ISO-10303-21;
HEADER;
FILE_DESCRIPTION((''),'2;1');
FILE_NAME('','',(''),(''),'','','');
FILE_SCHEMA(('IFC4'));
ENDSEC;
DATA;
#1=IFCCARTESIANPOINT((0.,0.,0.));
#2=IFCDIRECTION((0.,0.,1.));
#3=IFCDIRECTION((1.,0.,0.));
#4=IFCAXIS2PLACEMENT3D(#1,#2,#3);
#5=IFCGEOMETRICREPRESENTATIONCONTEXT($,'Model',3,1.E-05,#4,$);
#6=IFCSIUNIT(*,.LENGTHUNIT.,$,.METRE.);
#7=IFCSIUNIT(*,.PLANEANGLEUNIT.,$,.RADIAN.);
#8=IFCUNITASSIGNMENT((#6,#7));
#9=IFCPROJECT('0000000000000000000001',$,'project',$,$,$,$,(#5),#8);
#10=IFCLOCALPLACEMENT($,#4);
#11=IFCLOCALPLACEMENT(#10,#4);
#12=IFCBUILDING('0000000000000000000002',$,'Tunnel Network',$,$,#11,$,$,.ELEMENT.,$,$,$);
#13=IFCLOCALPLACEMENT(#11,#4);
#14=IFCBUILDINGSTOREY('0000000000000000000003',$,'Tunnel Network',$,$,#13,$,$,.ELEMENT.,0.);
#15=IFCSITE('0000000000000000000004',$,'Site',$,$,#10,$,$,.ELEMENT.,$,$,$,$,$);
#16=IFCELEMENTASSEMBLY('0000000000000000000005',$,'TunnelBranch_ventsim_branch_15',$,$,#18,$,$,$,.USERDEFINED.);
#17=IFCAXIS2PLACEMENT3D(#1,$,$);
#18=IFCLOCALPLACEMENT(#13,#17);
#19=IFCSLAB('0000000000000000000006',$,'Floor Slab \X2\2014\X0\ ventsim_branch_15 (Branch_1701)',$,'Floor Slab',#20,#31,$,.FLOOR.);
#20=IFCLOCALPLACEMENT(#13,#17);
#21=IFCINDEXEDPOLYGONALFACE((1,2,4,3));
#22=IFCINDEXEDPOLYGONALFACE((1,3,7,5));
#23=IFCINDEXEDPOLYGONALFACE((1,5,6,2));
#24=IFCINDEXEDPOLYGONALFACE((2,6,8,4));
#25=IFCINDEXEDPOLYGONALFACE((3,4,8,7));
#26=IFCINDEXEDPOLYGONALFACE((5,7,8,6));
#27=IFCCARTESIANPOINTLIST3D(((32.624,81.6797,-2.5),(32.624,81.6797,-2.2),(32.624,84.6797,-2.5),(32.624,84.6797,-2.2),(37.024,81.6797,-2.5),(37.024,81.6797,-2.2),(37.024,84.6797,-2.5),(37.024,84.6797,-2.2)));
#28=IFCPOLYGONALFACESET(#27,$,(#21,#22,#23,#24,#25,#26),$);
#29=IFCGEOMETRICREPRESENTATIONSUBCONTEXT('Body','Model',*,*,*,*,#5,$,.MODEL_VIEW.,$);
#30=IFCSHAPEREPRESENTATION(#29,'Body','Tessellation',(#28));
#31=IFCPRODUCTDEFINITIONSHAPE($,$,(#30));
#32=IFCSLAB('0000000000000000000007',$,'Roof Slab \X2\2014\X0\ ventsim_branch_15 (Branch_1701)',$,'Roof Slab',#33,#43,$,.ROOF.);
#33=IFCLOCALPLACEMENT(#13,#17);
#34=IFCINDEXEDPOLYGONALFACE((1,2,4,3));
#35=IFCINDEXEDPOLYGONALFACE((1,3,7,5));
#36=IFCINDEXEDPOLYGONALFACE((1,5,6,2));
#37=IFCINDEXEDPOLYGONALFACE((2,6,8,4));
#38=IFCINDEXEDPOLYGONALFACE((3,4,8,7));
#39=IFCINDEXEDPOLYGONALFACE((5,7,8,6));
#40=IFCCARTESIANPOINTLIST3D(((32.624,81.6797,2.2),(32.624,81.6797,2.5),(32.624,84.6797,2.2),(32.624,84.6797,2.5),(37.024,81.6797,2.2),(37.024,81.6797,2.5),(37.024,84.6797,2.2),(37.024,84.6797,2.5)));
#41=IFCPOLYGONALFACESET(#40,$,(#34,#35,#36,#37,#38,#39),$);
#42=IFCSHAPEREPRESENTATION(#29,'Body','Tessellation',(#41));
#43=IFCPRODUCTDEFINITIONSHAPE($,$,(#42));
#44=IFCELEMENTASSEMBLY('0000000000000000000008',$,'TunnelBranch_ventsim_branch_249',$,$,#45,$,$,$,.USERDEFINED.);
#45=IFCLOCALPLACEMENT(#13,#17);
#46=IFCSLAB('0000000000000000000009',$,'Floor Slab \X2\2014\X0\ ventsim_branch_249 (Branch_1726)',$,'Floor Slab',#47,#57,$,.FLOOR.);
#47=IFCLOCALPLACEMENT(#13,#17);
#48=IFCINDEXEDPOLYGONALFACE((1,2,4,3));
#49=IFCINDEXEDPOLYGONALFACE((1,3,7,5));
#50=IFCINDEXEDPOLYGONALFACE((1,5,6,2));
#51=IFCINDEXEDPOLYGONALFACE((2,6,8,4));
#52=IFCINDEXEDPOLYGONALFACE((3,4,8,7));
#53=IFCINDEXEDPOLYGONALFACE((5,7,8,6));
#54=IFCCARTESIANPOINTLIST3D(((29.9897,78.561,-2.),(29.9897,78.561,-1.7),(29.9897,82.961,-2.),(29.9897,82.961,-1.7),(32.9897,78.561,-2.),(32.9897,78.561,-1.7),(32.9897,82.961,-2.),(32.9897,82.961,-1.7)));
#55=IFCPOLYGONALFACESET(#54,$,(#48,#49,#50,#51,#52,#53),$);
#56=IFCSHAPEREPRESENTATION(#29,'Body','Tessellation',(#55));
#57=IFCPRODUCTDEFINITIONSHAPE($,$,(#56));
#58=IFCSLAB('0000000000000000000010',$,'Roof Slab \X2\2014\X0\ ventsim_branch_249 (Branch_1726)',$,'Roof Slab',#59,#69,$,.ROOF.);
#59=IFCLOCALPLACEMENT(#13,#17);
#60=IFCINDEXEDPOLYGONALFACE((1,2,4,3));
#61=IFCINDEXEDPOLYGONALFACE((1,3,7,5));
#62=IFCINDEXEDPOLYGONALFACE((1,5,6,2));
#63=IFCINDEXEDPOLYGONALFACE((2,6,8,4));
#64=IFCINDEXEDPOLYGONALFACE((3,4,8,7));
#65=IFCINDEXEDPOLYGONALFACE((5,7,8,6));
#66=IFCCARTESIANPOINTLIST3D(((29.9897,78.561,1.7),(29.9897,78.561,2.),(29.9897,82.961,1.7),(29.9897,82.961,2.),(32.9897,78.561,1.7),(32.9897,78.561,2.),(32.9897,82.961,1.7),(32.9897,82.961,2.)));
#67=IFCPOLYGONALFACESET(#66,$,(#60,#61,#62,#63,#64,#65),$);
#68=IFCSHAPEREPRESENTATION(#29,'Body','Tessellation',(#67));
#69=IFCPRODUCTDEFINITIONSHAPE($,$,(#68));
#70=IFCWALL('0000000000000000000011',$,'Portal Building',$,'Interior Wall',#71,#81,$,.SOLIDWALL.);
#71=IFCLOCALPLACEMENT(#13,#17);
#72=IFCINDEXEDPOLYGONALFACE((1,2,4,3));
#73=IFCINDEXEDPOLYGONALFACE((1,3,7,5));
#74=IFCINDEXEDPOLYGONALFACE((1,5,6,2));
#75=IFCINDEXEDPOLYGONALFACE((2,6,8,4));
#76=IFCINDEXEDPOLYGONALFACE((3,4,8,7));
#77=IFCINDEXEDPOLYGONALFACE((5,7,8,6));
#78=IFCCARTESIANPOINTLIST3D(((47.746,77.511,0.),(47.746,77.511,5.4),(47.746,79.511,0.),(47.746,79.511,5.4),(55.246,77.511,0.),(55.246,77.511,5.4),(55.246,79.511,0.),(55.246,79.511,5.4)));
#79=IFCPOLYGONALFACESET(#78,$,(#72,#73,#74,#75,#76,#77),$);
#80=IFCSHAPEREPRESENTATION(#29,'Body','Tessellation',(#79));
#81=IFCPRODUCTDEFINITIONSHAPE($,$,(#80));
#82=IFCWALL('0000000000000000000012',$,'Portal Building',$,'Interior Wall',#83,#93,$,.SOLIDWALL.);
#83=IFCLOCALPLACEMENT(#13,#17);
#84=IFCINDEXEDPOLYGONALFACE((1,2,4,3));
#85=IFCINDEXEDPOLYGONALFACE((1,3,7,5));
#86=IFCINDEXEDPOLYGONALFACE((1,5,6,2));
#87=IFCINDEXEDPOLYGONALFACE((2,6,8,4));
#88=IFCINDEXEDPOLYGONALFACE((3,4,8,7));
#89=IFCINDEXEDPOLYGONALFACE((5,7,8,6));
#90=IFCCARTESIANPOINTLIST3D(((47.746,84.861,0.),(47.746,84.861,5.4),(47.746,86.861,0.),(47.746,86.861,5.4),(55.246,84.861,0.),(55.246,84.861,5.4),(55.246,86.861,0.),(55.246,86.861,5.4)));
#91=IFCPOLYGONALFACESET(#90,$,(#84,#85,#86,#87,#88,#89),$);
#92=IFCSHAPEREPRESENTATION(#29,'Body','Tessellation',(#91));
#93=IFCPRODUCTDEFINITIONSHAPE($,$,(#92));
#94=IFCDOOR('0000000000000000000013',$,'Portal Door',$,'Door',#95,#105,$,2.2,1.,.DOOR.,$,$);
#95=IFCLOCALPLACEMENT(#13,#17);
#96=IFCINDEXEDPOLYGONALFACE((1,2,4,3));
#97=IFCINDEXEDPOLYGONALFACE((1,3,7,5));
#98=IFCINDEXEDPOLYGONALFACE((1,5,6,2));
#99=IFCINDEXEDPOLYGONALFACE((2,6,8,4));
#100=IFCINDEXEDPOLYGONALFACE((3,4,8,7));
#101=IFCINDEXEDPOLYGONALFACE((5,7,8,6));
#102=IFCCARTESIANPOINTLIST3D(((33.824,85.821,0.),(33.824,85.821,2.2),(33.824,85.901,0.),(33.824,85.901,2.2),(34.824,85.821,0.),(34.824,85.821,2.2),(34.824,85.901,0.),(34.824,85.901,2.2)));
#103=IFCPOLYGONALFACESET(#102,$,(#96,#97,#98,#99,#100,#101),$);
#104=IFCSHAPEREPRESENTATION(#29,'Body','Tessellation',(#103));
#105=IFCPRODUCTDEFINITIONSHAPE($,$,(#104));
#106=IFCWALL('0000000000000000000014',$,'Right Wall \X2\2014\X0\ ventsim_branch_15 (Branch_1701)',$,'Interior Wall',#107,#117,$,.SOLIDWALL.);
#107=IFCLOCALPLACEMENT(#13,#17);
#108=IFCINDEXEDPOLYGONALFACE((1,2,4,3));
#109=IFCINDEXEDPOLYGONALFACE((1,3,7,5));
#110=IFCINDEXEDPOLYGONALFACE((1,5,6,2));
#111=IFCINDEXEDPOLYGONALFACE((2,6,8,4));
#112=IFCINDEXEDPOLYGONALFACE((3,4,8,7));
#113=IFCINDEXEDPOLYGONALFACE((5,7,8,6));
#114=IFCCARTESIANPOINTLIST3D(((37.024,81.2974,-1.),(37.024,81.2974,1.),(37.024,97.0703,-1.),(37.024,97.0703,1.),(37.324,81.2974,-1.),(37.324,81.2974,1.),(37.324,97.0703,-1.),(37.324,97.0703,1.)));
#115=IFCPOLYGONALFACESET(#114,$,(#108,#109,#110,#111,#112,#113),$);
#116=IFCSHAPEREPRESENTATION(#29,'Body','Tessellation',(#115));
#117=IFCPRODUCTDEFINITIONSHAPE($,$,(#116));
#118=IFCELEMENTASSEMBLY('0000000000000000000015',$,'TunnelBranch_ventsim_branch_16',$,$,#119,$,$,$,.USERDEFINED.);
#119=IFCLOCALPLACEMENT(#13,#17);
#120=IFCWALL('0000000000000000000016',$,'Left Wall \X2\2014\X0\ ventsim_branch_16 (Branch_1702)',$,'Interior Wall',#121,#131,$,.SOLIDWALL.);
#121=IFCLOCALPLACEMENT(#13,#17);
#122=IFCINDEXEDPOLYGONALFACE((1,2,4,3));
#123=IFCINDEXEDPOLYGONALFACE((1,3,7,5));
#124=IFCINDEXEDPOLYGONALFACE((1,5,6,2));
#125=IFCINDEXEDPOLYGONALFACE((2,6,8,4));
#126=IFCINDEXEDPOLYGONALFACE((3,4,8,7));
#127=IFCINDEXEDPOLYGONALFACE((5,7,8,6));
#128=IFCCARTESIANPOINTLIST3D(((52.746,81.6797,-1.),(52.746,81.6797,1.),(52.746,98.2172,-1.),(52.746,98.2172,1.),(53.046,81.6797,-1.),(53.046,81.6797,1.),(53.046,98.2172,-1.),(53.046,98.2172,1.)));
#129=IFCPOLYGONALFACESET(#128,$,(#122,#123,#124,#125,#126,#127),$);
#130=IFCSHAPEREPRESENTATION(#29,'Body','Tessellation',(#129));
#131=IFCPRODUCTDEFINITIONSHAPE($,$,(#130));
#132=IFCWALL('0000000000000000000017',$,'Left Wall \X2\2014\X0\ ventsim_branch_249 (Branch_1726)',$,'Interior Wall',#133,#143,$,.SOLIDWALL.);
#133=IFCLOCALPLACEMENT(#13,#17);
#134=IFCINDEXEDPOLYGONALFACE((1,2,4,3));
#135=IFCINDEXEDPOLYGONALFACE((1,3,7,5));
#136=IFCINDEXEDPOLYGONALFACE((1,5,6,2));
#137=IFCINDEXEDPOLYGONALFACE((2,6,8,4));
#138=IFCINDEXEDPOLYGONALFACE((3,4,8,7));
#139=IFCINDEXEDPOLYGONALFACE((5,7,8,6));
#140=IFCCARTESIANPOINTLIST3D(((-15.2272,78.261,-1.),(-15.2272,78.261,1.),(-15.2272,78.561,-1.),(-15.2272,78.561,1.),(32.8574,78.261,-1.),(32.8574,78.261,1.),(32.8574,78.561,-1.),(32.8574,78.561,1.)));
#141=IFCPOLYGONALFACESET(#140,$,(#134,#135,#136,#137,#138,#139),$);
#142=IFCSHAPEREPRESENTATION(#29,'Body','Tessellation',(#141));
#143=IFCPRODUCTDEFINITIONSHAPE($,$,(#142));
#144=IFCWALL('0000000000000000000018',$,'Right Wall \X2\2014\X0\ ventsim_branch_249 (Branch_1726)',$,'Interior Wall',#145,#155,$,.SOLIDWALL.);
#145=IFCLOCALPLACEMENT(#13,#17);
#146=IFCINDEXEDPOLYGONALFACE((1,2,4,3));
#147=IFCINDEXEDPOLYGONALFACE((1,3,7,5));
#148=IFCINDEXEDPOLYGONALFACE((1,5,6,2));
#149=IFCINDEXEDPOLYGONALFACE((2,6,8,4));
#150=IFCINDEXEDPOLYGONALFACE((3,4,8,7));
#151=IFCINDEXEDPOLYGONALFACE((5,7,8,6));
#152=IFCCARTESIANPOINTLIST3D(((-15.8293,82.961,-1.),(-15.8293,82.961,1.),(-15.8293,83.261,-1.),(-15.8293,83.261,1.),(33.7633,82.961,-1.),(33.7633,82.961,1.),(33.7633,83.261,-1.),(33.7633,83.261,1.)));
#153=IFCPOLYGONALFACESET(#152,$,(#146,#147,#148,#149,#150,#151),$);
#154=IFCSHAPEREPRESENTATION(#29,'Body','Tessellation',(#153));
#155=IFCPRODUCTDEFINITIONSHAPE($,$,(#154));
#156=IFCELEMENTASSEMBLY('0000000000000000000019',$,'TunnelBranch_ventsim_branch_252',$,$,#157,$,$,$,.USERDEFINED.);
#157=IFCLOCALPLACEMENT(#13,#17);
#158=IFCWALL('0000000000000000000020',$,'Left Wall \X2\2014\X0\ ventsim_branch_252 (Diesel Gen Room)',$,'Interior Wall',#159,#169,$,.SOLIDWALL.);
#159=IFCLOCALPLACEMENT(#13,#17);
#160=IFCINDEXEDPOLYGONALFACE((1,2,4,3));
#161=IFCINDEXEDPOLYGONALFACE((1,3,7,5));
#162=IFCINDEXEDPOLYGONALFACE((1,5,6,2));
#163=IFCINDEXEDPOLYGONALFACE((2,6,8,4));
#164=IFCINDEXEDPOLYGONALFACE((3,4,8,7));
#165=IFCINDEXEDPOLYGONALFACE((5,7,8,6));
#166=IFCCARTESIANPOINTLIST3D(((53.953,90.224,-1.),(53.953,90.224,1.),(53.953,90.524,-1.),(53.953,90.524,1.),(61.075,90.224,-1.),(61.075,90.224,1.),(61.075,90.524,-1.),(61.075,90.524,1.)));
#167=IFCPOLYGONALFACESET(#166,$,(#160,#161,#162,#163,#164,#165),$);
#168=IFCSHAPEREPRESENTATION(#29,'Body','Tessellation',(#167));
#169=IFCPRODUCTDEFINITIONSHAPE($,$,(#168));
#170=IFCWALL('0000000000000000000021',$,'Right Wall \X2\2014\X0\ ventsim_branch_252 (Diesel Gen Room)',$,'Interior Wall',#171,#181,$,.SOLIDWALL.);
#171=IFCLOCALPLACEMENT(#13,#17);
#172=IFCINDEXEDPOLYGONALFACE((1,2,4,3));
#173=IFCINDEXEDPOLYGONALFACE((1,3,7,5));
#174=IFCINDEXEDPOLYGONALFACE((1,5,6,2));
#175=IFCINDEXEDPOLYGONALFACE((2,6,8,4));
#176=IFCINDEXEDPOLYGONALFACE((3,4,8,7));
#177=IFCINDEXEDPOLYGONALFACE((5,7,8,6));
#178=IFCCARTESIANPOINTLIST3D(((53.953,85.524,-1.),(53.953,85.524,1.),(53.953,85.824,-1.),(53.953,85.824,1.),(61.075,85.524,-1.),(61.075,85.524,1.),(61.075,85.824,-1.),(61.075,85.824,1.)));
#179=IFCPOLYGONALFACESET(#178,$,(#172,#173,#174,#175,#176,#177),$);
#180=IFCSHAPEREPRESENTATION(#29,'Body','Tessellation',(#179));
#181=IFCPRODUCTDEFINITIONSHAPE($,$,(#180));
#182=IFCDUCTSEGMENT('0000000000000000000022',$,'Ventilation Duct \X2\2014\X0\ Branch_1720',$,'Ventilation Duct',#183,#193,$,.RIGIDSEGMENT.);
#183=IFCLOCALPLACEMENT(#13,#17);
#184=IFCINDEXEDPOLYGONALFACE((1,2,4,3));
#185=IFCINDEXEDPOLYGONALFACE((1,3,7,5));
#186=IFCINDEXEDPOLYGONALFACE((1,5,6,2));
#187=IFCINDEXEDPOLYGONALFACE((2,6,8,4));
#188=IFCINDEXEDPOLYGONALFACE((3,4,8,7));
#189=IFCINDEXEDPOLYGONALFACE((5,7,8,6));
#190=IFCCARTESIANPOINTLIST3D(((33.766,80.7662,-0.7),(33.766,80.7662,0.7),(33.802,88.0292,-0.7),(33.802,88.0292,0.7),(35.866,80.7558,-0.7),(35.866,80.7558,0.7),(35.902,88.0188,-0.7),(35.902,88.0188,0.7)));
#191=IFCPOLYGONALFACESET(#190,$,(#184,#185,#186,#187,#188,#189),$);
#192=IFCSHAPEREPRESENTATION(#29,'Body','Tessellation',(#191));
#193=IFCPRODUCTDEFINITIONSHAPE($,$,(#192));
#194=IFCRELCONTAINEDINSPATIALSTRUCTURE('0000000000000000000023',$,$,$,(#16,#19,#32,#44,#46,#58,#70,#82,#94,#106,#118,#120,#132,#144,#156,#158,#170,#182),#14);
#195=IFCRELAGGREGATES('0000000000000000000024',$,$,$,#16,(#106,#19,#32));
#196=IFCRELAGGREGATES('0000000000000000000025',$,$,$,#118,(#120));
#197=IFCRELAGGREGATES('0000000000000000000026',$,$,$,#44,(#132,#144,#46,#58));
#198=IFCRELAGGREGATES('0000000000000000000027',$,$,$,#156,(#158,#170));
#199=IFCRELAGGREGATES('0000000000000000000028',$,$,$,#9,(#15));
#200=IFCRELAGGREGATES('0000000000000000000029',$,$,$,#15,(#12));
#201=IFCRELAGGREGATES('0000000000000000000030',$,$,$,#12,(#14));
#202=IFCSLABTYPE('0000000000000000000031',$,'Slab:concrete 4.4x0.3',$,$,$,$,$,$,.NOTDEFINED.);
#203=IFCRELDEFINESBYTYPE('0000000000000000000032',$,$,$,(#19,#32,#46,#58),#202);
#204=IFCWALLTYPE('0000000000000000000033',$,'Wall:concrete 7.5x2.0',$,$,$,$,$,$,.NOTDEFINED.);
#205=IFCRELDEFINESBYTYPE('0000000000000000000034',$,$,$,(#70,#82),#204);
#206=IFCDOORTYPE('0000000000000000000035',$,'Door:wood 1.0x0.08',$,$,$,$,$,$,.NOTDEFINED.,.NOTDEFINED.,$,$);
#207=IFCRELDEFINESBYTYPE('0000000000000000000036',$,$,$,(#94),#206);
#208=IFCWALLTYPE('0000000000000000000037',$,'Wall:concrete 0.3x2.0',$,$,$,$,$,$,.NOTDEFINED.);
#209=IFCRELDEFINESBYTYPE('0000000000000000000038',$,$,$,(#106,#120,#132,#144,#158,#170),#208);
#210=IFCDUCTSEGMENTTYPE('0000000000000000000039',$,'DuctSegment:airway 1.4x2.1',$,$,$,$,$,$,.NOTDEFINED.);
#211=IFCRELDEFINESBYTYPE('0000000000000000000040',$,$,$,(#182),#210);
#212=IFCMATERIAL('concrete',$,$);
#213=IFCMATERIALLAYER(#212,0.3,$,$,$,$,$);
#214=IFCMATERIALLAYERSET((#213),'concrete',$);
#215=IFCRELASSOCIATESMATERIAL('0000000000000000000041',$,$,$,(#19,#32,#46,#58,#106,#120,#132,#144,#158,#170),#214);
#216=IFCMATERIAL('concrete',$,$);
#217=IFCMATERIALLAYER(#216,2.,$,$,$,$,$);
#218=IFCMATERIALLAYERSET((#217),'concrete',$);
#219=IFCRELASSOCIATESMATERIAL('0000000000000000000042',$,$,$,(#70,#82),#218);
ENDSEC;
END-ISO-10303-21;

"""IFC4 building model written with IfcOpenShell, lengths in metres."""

from ifc_helpers import new_model, si_unit, frame, origin_with_axes, origin_2d_with_axis, place, context, subcontext, project, spatial, rectangle, extrude, material, layer, layer_set, layer_usage, type_object, element, aggregate, save


model = new_model("IFC4")

# Units and contexts
model_context = context("Model", 3, precision=1e-05, world=origin_with_axes())
body_context = subcontext(model_context, "Body", "Model", "MODEL_VIEW")
ifc_project = project(units=[si_unit("LENGTHUNIT", "METRE"), si_unit("PLANEANGLEUNIT", "RADIAN")], contexts=[model_context])

# Site, building, storey
site_placement = place(None, origin_with_axes())
site = spatial("IfcSite", under=ifc_project, at=site_placement, Name="Site", CompositionType="ELEMENT")
building_placement = place(site_placement, origin_with_axes())
building = spatial("IfcBuilding", under=site, at=building_placement, Name="Tunnel Network", CompositionType="ELEMENT")
storey_placement = place(building_placement, origin_with_axes())
storey = spatial("IfcBuildingStorey", under=building, at=storey_placement, Name="Tunnel Network", CompositionType="ELEMENT", Elevation=0.0)

# Element assemblies, slabs
assembly_1_placement = place(storey_placement, frame((32.474, 81.6797, 0.0), z_axis=(0.0, 1.0, 0.0), x_axis=(1.0, 0.0, 0.0)))
assembly_1 = element("IfcElementAssembly", 1, at=assembly_1_placement, inside=storey, Name="TunnelBranch_ventsim_branch_15", PredefinedType="USERDEFINED")
ifc_material_1 = material(Name="concrete")
ifc_layer_1 = layer(ifc_material_1, 0.3)
ifc_layer_set_1 = layer_set([ifc_layer_1], Name="concrete")
ifc_layer_usage_1 = layer_usage(ifc_layer_set_1, "AXIS3", "POSITIVE", 0.0)
slab_type = type_object("IfcSlabType", Name="Slab:concrete 4.4x0.3")
slab_1_placement = place(storey_placement, frame((34.824, 81.6797, -2.35), z_axis=(0.0, 1.0, 0.0), x_axis=(1.0, 0.0, 0.0)))
slab_1 = element("IfcSlab", 2, at=slab_1_placement, inside=storey, type_object=slab_type, material=ifc_layer_usage_1, Name="Floor Slab — ventsim_branch_15 (Branch_1701)", ObjectType="Floor Slab", PredefinedType="FLOOR", context=body_context, shape_type="SweptSolid", body=[
    extrude(rectangle(XDim=4.4, YDim=0.3, at=origin_2d_with_axis()), origin_with_axes(), (0.0, 0.0, 1.0), 3.0),
])
ifc_layer_usage_2 = layer_usage(ifc_layer_set_1, "AXIS3", "POSITIVE", 0.0)
slab_2_placement = place(storey_placement, frame((34.824, 81.6797, 2.35), z_axis=(0.0, 1.0, 0.0), x_axis=(1.0, 0.0, 0.0)))
slab_2 = element("IfcSlab", 3, at=slab_2_placement, inside=storey, type_object=slab_type, material=ifc_layer_usage_2, Name="Roof Slab — ventsim_branch_15 (Branch_1701)", ObjectType="Roof Slab", PredefinedType="ROOF", context=body_context, shape_type="SweptSolid", body=[
    extrude(rectangle(XDim=4.4, YDim=0.3, at=origin_2d_with_axis()), origin_with_axes(), (0.0, 0.0, 1.0), 3.0),
])
assembly_2_placement = place(storey_placement, frame((32.8574, 78.411, 0.0), z_axis=(-1.0, 0.0, 0.0), x_axis=(0.0, 1.0, 0.0)))
assembly_2 = element("IfcElementAssembly", 4, at=assembly_2_placement, inside=storey, Name="TunnelBranch_ventsim_branch_249", PredefinedType="USERDEFINED")
ifc_layer_usage_3 = layer_usage(ifc_layer_set_1, "AXIS3", "POSITIVE", 0.0)
slab_3_placement = place(storey_placement, frame((32.9897, 80.761, -1.85), z_axis=(-1.0, 0.0, 0.0), x_axis=(0.0, 1.0, 0.0)))
slab_3 = element("IfcSlab", 5, at=slab_3_placement, inside=storey, type_object=slab_type, material=ifc_layer_usage_3, Name="Floor Slab — ventsim_branch_249 (Branch_1726)", ObjectType="Floor Slab", PredefinedType="FLOOR", context=body_context, shape_type="SweptSolid", body=[
    extrude(rectangle(XDim=4.4, YDim=0.3, at=origin_2d_with_axis()), origin_with_axes(), (0.0, 0.0, 1.0), 3.0),
])
ifc_layer_usage_4 = layer_usage(ifc_layer_set_1, "AXIS3", "POSITIVE", 0.0)
slab_4_placement = place(storey_placement, frame((32.9897, 80.761, 1.85), z_axis=(-1.0, 0.0, 0.0), x_axis=(0.0, 1.0, 0.0)))
slab_4 = element("IfcSlab", 6, at=slab_4_placement, inside=storey, type_object=slab_type, material=ifc_layer_usage_4, Name="Roof Slab — ventsim_branch_249 (Branch_1726)", ObjectType="Roof Slab", PredefinedType="ROOF", context=body_context, shape_type="SweptSolid", body=[
    extrude(rectangle(XDim=4.4, YDim=0.3, at=origin_2d_with_axis()), origin_with_axes(), (0.0, 0.0, 1.0), 3.0),
])

# Walls
ifc_material_2 = material(Name="concrete")
ifc_layer_2 = layer(ifc_material_2, 2.0)
ifc_layer_set_2 = layer_set([ifc_layer_2], Name="concrete")
ifc_layer_usage_5 = layer_usage(ifc_layer_set_2, "AXIS2", "POSITIVE", 0.0)
wall_type_1 = type_object("IfcWallType", Name="Wall:concrete 7.5x2.0")
wall_1_placement = place(storey_placement, frame((51.496, 78.511, 0.0), z_axis=(0.0, 0.0, 1.0), x_axis=(1.0, 0.0, 0.0)))
element("IfcWall", 7, at=wall_1_placement, inside=storey, type_object=wall_type_1, material=ifc_layer_usage_5, Name="Portal Building", ObjectType="Interior Wall", PredefinedType="SOLIDWALL", context=body_context, shape_type="SweptSolid", body=[
    extrude(rectangle(XDim=7.5, YDim=2.0, at=origin_2d_with_axis()), origin_with_axes(), (0.0, 0.0, 1.0), 5.4),
])
ifc_layer_usage_6 = layer_usage(ifc_layer_set_2, "AXIS2", "POSITIVE", 0.0)
wall_2_placement = place(storey_placement, frame((51.496, 85.861, 0.0), z_axis=(0.0, 0.0, 1.0), x_axis=(1.0, 0.0, 0.0)))
element("IfcWall", 8, at=wall_2_placement, inside=storey, type_object=wall_type_1, material=ifc_layer_usage_6, Name="Portal Building", ObjectType="Interior Wall", PredefinedType="SOLIDWALL", context=body_context, shape_type="SweptSolid", body=[
    extrude(rectangle(XDim=7.5, YDim=2.0, at=origin_2d_with_axis()), origin_with_axes(), (0.0, 0.0, 1.0), 5.4),
])

# Door
door_type = type_object("IfcDoorType", Name="Door:wood 1.0x0.08")
door_placement = place(storey_placement, frame((34.324, 85.861, 0.0), z_axis=(0.0, 0.0, 1.0), x_axis=(1.0, 0.0, 0.0)))
element("IfcDoor", 9, at=door_placement, inside=storey, type_object=door_type, Name="Portal Door", ObjectType="Door", OverallHeight=2.2, OverallWidth=1.0, PredefinedType="DOOR", context=body_context, shape_type="SweptSolid", body=[
    extrude(rectangle(XDim=1.0, YDim=0.08, at=origin_2d_with_axis()), origin_with_axes(), (0.0, 0.0, 1.0), 2.2),
])

# Wall
ifc_layer_usage_7 = layer_usage(ifc_layer_set_1, "AXIS2", "POSITIVE", 0.0)
wall_type_2 = type_object("IfcWallType", Name="Wall:concrete 0.3x2.0")
wall_3_placement = place(storey_placement, frame((37.174, 81.2974, 0.0), z_axis=(0.0, 1.0, 0.0), x_axis=(1.0, 0.0, 0.0)))
wall_3 = element("IfcWall", 10, at=wall_3_placement, inside=storey, type_object=wall_type_2, material=ifc_layer_usage_7, Name="Right Wall — ventsim_branch_15 (Branch_1701)", ObjectType="Interior Wall", PredefinedType="SOLIDWALL", context=body_context, shape_type="SweptSolid", body=[
    extrude(rectangle(XDim=0.3, YDim=2.0, at=origin_2d_with_axis()), origin_with_axes(), (0.0, 0.0, 1.0), 15.7728),
])
aggregate(assembly_1, [wall_3, slab_1, slab_2])

# Element assembly, wall
assembly_3_placement = place(storey_placement, frame((52.896, 81.6797, 0.0), z_axis=(0.0, 1.0, 0.0), x_axis=(1.0, 0.0, 0.0)))
assembly_3 = element("IfcElementAssembly", 11, at=assembly_3_placement, inside=storey, Name="TunnelBranch_ventsim_branch_16", PredefinedType="USERDEFINED")
ifc_layer_usage_8 = layer_usage(ifc_layer_set_1, "AXIS2", "POSITIVE", 0.0)
wall_4_placement = place(storey_placement, frame((52.896, 81.6797, 0.0), z_axis=(0.0, 1.0, 0.0), x_axis=(1.0, 0.0, 0.0)))
wall_4 = element("IfcWall", 12, at=wall_4_placement, inside=storey, type_object=wall_type_2, material=ifc_layer_usage_8, Name="Left Wall — ventsim_branch_16 (Branch_1702)", ObjectType="Interior Wall", PredefinedType="SOLIDWALL", context=body_context, shape_type="SweptSolid", body=[
    extrude(rectangle(XDim=0.3, YDim=2.0, at=origin_2d_with_axis()), origin_with_axes(), (0.0, 0.0, 1.0), 16.5375),
])
aggregate(assembly_3, [wall_4])

# Walls
ifc_layer_usage_9 = layer_usage(ifc_layer_set_1, "AXIS2", "POSITIVE", 0.0)
wall_5_placement = place(storey_placement, frame((32.8574, 78.411, 0.0), z_axis=(-1.0, 0.0, 0.0), x_axis=(0.0, 1.0, 0.0)))
wall_5 = element("IfcWall", 13, at=wall_5_placement, inside=storey, type_object=wall_type_2, material=ifc_layer_usage_9, Name="Left Wall — ventsim_branch_249 (Branch_1726)", ObjectType="Interior Wall", PredefinedType="SOLIDWALL", context=body_context, shape_type="SweptSolid", body=[
    extrude(rectangle(XDim=0.3, YDim=2.0, at=origin_2d_with_axis()), origin_with_axes(), (0.0, 0.0, 1.0), 48.0847),
])
ifc_layer_usage_10 = layer_usage(ifc_layer_set_1, "AXIS2", "POSITIVE", 0.0)
wall_6_placement = place(storey_placement, frame((33.7633, 83.111, 0.0), z_axis=(-1.0, 0.0, 0.0), x_axis=(0.0, 1.0, 0.0)))
wall_6 = element("IfcWall", 14, at=wall_6_placement, inside=storey, type_object=wall_type_2, material=ifc_layer_usage_10, Name="Right Wall — ventsim_branch_249 (Branch_1726)", ObjectType="Interior Wall", PredefinedType="SOLIDWALL", context=body_context, shape_type="SweptSolid", body=[
    extrude(rectangle(XDim=0.3, YDim=2.0, at=origin_2d_with_axis()), origin_with_axes(), (0.0, 0.0, 1.0), 49.5926),
])
aggregate(assembly_2, [wall_5, wall_6, slab_3, slab_4])

# Element assembly, walls
assembly_4_placement = place(storey_placement, frame((53.953, 90.374, 0.0), z_axis=(1.0, 0.0, 0.0), x_axis=(0.0, -1.0, 0.0)))
assembly_4 = element("IfcElementAssembly", 15, at=assembly_4_placement, inside=storey, Name="TunnelBranch_ventsim_branch_252", PredefinedType="USERDEFINED")
ifc_layer_usage_11 = layer_usage(ifc_layer_set_1, "AXIS2", "POSITIVE", 0.0)
wall_7_placement = place(storey_placement, frame((53.953, 90.374, 0.0), z_axis=(1.0, 0.0, 0.0), x_axis=(0.0, -1.0, 0.0)))
wall_7 = element("IfcWall", 16, at=wall_7_placement, inside=storey, type_object=wall_type_2, material=ifc_layer_usage_11, Name="Left Wall — ventsim_branch_252 (Diesel Gen Room)", ObjectType="Interior Wall", PredefinedType="SOLIDWALL", context=body_context, shape_type="SweptSolid", body=[
    extrude(rectangle(XDim=0.3, YDim=2.0, at=origin_2d_with_axis()), origin_with_axes(), (0.0, 0.0, 1.0), 7.122),
])
ifc_layer_usage_12 = layer_usage(ifc_layer_set_1, "AXIS2", "POSITIVE", 0.0)
wall_8_placement = place(storey_placement, frame((53.953, 85.674, 0.0), z_axis=(1.0, 0.0, 0.0), x_axis=(0.0, -1.0, 0.0)))
wall_8 = element("IfcWall", 17, at=wall_8_placement, inside=storey, type_object=wall_type_2, material=ifc_layer_usage_12, Name="Right Wall — ventsim_branch_252 (Diesel Gen Room)", ObjectType="Interior Wall", PredefinedType="SOLIDWALL", context=body_context, shape_type="SweptSolid", body=[
    extrude(rectangle(XDim=0.3, YDim=2.0, at=origin_2d_with_axis()), origin_with_axes(), (0.0, 0.0, 1.0), 7.122),
])
aggregate(assembly_4, [wall_7, wall_8])

# Duct segment
duct_segment_type_1 = type_object("IfcDuctSegmentType", Name="DuctSegment:airway 1.4x2.1")
duct_segment_1_placement = place(storey_placement, frame((34.816, 80.761, 0.0), z_axis=(0.004956, 0.999988, 0.0), x_axis=(0.0, 0.0, 1.0)))
element("IfcDuctSegment", 18, at=duct_segment_1_placement, inside=storey, type_object=duct_segment_type_1, Name="Ventilation Duct — Branch_1720", ObjectType="Ventilation Duct", PredefinedType="RIGIDSEGMENT", context=body_context, shape_type="SweptSolid", body=[
    extrude(rectangle(XDim=1.4, YDim=2.1, at=origin_2d_with_axis()), origin_with_axes(), (0.0, 0.0, 1.0), 7.2631),
])

save(model, "model.ifc")
